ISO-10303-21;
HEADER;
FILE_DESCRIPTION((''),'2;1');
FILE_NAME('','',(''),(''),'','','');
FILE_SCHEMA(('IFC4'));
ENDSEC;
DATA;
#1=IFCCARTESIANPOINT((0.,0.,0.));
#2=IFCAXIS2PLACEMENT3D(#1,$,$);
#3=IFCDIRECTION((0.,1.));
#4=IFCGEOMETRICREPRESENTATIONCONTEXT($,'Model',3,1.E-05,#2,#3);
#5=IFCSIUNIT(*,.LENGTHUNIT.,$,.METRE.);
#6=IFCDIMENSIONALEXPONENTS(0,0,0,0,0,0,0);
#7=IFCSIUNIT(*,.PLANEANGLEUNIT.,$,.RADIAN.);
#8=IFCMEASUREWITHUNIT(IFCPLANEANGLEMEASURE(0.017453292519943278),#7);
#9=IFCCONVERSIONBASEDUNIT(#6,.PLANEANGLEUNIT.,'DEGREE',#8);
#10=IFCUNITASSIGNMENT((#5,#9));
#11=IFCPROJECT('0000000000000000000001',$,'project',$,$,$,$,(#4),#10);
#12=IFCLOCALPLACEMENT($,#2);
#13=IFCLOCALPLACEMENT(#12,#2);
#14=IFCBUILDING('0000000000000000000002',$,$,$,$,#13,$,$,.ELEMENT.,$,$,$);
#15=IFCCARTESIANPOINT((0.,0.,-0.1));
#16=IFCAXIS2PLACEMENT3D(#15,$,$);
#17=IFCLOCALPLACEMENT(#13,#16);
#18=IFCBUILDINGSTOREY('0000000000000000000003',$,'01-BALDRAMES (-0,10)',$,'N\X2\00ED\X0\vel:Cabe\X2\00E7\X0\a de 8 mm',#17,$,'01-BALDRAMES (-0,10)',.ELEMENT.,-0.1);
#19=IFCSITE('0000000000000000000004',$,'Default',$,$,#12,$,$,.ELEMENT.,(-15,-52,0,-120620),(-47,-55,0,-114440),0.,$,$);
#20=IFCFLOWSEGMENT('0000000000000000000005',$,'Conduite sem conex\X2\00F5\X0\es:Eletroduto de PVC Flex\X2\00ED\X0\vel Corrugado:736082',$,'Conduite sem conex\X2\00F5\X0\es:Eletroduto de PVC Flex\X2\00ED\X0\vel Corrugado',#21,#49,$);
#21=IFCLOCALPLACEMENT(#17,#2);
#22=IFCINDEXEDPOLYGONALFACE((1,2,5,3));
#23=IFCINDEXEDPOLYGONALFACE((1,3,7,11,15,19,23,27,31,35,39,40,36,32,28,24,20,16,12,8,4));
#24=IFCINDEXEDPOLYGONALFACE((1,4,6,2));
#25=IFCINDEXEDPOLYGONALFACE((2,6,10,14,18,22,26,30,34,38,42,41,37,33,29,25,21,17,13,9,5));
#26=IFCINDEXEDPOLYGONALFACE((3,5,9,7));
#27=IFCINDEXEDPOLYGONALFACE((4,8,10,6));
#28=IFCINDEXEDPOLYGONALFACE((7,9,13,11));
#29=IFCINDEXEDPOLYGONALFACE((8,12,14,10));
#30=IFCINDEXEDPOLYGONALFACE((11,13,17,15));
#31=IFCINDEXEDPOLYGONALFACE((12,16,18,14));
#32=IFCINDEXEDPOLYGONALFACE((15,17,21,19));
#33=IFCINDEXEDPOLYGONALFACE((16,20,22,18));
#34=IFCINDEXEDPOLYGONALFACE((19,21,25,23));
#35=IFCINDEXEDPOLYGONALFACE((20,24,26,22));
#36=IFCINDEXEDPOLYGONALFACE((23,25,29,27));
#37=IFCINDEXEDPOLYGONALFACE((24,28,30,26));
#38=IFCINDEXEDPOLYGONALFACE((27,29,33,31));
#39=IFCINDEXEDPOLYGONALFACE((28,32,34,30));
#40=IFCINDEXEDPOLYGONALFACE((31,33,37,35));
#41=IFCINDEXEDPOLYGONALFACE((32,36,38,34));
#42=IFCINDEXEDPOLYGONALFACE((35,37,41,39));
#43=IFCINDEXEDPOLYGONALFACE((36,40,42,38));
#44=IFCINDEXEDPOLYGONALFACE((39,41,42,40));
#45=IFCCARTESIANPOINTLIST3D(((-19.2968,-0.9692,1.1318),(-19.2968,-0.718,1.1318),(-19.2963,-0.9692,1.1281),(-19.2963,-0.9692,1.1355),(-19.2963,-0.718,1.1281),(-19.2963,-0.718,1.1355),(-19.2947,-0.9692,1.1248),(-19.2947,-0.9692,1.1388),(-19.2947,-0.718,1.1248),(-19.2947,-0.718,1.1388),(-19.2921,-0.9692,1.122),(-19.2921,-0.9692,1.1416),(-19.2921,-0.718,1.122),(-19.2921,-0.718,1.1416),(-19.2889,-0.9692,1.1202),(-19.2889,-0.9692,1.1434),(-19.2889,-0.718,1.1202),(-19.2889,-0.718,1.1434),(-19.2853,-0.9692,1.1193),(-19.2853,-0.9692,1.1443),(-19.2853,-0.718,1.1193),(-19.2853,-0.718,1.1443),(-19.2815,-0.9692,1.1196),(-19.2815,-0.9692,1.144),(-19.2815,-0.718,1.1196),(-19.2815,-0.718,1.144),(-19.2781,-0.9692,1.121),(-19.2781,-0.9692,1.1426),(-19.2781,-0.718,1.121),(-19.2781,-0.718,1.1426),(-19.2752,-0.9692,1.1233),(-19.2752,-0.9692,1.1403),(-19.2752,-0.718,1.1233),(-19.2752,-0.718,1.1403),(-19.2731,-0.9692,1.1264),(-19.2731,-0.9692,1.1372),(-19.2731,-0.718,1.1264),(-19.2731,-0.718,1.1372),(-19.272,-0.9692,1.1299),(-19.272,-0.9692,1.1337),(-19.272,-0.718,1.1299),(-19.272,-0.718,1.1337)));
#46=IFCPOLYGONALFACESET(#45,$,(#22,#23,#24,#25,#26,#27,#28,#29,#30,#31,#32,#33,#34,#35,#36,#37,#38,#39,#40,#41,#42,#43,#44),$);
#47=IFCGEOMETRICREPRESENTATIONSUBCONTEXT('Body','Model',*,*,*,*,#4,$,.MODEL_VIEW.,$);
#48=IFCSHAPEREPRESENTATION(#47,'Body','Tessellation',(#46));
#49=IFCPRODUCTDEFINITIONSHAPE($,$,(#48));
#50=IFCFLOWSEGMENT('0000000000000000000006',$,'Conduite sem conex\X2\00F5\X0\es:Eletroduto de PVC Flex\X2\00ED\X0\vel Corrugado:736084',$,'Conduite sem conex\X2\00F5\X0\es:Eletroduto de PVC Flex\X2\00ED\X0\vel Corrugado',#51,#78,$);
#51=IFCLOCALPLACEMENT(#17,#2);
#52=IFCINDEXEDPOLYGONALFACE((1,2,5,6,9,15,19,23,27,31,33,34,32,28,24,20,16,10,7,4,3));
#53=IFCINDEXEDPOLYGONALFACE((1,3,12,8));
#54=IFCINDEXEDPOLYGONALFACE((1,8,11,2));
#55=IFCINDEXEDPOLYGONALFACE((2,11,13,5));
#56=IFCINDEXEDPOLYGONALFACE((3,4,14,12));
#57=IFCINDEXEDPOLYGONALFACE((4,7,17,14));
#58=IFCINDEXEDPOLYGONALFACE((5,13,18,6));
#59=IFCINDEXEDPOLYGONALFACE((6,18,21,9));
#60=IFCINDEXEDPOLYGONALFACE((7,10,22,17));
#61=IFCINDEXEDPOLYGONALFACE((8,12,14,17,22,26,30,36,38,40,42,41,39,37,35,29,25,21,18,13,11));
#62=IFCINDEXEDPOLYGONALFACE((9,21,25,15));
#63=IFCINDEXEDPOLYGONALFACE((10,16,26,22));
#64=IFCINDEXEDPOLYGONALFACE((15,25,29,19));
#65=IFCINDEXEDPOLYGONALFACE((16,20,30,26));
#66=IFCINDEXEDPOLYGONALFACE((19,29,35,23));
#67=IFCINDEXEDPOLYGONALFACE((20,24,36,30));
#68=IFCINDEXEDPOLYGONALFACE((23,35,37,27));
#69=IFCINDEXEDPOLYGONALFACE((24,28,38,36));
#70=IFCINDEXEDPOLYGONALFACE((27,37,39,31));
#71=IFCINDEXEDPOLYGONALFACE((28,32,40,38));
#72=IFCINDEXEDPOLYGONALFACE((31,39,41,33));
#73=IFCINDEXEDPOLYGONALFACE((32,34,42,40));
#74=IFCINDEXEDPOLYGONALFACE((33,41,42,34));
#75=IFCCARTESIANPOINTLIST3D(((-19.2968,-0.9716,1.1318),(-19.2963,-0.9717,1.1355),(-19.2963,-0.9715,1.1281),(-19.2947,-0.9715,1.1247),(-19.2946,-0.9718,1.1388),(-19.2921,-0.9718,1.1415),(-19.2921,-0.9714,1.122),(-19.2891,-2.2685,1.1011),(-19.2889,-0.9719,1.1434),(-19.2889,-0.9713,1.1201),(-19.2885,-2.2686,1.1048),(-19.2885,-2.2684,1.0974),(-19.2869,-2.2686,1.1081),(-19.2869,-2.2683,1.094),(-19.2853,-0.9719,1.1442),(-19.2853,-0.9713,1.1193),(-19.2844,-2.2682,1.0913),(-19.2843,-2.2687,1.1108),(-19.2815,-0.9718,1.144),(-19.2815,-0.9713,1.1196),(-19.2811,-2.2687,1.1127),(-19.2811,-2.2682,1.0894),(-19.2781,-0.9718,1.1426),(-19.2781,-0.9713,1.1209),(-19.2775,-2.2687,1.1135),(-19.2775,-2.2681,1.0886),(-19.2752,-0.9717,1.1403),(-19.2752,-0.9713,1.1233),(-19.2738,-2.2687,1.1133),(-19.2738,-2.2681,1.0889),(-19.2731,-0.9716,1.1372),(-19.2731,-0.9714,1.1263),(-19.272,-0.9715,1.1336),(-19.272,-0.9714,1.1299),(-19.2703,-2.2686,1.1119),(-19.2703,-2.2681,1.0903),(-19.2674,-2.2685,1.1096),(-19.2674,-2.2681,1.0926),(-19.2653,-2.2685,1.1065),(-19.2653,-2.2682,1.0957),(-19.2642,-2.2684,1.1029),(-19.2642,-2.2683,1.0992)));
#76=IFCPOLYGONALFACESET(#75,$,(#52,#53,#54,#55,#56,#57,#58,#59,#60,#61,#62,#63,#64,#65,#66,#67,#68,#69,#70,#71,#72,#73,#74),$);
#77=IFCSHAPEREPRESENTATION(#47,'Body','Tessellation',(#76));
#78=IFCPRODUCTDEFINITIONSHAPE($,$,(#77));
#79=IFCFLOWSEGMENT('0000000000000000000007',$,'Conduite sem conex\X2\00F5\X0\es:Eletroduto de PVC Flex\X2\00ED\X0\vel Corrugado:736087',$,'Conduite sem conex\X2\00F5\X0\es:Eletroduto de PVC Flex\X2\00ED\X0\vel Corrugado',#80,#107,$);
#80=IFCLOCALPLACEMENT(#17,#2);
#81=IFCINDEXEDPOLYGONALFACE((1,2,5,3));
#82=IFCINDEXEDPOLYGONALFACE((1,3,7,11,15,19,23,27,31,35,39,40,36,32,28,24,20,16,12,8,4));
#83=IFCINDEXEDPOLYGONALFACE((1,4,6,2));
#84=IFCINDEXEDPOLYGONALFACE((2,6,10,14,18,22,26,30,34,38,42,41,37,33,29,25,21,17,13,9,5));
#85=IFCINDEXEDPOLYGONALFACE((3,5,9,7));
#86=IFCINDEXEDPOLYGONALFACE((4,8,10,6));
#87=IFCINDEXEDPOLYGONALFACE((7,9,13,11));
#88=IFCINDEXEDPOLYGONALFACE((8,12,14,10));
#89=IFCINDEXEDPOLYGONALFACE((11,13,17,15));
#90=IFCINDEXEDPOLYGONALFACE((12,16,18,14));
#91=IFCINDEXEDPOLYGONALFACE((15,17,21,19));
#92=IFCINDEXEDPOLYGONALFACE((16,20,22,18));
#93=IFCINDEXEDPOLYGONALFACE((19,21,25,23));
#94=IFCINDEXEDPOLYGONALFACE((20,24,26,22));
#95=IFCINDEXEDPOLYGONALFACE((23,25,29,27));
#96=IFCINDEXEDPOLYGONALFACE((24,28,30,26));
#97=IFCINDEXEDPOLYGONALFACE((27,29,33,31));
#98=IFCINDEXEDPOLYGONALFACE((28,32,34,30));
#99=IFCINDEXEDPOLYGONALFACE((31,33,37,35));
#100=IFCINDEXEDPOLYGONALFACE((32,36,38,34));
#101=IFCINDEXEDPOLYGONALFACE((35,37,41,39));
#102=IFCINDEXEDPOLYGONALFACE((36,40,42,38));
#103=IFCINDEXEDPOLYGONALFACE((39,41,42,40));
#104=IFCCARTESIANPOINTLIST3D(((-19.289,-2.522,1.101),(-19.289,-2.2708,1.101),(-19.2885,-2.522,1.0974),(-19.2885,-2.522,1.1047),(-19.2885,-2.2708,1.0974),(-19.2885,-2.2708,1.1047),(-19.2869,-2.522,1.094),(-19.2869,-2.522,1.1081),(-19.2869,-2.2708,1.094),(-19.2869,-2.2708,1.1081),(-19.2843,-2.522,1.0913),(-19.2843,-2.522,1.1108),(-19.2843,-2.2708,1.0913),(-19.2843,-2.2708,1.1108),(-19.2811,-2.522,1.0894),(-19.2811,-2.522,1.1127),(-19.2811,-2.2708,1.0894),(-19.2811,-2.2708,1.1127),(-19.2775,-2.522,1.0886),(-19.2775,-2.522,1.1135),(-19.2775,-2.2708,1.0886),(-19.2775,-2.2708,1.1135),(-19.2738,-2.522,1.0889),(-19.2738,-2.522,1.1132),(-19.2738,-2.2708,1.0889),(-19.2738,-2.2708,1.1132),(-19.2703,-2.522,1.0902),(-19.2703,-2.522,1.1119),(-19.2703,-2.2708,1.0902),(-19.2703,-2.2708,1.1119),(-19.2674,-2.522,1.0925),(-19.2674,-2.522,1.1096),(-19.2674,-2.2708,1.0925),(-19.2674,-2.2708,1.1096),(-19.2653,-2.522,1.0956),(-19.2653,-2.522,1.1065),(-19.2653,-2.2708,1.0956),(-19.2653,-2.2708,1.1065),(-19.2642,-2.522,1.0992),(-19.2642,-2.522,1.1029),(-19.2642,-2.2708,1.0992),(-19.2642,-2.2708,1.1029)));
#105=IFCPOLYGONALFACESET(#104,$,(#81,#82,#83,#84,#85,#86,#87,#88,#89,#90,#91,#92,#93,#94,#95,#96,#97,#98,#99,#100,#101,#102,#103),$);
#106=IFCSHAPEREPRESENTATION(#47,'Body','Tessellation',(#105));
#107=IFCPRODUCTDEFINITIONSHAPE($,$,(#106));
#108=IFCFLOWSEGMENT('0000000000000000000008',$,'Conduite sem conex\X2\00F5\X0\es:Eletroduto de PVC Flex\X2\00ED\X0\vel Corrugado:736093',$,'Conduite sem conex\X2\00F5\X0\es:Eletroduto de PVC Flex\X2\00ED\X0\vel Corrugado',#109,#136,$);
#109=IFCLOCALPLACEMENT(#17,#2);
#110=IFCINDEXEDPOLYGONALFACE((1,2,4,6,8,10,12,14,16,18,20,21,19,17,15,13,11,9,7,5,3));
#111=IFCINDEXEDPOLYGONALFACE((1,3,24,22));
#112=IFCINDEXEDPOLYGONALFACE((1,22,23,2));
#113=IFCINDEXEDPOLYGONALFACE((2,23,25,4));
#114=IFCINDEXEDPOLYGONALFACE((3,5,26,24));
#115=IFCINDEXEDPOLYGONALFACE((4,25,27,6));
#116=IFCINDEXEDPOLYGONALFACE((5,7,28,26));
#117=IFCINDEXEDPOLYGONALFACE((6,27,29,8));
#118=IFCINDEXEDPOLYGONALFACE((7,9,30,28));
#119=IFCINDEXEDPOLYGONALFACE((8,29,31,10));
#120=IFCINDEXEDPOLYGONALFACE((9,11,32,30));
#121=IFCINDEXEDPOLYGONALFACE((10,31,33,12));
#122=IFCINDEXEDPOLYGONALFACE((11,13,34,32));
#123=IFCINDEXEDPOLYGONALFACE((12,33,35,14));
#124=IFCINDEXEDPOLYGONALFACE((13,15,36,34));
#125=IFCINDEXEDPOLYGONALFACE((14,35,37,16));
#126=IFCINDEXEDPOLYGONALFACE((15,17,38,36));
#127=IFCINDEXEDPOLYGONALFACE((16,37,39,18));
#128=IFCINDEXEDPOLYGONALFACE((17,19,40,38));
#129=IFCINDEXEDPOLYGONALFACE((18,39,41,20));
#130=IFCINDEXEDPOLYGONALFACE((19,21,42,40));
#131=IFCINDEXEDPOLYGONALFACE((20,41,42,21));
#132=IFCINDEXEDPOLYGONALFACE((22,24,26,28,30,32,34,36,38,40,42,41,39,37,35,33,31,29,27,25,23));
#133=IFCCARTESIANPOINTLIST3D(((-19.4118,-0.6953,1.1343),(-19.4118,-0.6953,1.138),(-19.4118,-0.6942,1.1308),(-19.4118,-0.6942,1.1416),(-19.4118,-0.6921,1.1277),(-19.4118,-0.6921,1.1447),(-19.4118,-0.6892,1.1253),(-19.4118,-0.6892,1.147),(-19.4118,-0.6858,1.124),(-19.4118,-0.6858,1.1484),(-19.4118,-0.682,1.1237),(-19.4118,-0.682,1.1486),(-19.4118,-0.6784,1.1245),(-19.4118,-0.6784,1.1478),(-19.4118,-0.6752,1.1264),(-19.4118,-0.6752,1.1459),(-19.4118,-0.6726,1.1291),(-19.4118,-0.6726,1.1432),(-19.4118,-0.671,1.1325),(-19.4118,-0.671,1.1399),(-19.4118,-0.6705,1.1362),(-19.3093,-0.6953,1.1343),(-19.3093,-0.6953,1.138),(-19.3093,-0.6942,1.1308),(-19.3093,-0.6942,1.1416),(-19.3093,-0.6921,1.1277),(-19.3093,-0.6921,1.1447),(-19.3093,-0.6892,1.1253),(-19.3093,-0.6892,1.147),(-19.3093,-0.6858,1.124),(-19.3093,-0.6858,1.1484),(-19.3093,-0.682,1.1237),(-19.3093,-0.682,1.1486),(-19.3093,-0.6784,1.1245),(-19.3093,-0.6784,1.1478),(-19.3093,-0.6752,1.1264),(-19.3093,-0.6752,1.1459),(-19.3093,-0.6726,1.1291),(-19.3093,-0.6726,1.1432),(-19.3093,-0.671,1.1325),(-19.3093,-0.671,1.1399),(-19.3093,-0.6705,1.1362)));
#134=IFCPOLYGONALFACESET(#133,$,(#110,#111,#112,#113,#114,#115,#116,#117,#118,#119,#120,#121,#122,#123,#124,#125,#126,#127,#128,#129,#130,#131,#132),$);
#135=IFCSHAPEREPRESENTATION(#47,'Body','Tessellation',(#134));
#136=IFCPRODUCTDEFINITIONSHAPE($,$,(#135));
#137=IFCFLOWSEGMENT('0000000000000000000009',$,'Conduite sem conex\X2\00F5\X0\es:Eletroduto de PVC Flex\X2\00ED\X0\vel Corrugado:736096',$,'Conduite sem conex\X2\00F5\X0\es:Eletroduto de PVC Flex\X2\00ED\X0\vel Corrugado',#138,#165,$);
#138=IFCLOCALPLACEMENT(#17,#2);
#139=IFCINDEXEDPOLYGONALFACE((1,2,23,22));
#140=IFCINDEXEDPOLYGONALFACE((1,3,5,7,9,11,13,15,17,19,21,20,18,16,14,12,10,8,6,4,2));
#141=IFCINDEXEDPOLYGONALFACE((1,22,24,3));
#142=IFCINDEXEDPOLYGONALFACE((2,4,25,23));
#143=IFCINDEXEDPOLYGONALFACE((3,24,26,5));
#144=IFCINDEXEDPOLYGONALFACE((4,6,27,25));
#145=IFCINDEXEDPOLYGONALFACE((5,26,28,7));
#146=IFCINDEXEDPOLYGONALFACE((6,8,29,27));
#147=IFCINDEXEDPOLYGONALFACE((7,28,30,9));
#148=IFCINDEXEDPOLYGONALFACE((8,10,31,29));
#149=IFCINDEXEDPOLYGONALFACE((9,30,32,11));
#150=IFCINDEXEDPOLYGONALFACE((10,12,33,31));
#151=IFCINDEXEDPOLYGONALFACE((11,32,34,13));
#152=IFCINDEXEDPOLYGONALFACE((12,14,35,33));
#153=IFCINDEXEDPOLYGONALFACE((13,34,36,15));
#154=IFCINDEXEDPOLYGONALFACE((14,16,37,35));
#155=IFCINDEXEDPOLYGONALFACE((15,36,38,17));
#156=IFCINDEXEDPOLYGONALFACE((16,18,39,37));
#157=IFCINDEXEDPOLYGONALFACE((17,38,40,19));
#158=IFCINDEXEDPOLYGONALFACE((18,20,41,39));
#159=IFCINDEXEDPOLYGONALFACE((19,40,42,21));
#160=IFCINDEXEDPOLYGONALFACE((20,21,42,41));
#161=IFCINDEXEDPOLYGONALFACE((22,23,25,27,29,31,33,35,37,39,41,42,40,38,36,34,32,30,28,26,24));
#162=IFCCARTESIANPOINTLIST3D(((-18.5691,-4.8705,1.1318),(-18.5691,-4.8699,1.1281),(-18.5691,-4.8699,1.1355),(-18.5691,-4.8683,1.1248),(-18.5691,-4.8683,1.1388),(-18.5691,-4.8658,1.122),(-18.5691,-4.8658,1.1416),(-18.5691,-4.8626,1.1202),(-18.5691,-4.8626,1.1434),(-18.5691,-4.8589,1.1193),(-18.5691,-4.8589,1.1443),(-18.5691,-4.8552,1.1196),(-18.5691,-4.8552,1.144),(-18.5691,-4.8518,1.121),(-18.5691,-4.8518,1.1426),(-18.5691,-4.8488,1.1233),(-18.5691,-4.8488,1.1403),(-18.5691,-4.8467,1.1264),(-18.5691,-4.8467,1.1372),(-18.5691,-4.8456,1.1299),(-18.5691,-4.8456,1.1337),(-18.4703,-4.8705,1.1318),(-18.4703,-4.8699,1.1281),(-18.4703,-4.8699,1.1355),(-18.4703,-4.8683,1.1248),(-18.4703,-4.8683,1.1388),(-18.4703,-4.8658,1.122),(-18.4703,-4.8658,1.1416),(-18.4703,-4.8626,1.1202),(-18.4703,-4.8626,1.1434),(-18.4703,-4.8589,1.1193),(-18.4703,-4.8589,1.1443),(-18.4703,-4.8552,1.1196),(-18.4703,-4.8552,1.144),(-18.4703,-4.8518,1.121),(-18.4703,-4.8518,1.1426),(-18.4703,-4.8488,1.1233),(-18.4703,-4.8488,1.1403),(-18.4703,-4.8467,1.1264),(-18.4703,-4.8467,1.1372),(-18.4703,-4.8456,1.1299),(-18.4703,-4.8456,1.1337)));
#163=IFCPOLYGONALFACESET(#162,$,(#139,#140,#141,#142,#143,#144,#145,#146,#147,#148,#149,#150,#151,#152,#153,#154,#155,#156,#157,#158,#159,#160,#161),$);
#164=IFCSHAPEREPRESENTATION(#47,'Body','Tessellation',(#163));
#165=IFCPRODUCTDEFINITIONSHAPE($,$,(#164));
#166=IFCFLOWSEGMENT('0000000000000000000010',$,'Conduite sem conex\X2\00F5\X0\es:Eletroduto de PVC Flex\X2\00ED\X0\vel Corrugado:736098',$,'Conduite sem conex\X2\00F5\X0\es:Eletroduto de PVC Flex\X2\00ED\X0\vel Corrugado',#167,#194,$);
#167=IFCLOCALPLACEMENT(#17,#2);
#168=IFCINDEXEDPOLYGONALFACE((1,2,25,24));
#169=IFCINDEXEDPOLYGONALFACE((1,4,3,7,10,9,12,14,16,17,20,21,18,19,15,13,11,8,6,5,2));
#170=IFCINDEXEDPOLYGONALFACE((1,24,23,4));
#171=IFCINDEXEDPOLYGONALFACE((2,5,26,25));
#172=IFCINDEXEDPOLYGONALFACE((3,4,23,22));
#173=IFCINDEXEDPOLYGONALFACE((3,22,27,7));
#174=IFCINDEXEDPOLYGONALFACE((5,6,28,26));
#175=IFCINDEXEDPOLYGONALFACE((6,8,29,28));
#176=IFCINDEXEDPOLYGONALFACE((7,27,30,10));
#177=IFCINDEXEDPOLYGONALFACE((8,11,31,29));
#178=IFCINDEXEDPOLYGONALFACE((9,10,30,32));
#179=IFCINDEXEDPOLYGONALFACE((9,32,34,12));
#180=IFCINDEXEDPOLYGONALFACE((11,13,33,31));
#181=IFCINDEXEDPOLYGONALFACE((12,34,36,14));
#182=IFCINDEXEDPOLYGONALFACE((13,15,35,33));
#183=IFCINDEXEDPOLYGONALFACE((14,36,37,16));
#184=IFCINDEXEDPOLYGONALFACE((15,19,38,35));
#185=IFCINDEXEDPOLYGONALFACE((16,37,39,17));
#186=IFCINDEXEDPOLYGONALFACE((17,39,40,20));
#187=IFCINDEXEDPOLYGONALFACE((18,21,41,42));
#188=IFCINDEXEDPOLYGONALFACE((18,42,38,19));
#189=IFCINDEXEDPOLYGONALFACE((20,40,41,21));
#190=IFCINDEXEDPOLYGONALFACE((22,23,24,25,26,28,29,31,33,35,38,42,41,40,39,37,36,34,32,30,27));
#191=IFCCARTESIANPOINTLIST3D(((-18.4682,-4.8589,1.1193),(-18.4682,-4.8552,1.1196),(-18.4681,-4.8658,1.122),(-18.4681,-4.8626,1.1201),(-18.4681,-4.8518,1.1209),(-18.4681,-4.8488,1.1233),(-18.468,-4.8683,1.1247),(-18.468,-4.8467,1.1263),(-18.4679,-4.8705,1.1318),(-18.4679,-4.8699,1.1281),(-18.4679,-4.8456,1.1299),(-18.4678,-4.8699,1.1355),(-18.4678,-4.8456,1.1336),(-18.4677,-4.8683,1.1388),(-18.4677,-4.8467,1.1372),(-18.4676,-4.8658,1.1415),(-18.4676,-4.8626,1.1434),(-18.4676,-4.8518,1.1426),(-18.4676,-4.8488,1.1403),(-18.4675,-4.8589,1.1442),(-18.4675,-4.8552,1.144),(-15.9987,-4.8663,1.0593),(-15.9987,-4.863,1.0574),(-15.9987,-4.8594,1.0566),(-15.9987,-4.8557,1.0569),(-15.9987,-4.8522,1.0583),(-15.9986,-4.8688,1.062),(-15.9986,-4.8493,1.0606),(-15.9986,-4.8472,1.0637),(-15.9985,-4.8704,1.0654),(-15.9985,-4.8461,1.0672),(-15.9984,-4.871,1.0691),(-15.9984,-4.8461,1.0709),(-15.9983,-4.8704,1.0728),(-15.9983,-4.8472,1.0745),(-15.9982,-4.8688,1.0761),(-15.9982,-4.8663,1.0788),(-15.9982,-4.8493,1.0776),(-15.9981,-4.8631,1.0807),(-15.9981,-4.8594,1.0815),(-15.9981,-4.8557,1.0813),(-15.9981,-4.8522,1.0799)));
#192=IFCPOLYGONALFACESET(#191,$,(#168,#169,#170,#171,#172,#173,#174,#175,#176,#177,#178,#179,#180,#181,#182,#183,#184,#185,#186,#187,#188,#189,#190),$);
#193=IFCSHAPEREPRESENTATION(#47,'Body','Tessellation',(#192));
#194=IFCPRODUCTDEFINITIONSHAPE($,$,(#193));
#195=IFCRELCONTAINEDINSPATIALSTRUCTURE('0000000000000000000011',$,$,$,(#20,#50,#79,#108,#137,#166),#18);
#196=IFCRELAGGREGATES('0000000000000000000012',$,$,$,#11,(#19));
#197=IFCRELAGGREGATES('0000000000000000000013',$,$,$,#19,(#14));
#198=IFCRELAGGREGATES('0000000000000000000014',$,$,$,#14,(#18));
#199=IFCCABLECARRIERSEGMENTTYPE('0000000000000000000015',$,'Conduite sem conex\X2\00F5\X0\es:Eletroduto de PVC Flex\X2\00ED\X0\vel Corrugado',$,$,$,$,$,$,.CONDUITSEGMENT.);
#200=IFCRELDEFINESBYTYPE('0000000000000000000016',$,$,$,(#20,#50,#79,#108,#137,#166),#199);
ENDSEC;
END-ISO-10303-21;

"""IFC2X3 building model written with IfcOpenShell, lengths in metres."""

from ifc_helpers import new_model, entity, si_unit, converted_unit, direction, frame, frame_2d, origin, origin_2d_with_axis, place, context, subcontext, project, spatial, circle, extrude, type_object, element, save


model = new_model("IFC2X3")

# Units and contexts
model_context = context("Model", 3, precision=1e-05, world=origin(), true_north=direction((0.0, 1.0)))
body_context = subcontext(model_context, "Body", "Model", "MODEL_VIEW")
ifc_project = project(units=[si_unit("LENGTHUNIT", "METRE"), converted_unit("PLANEANGLEUNIT", "DEGREE", entity("IfcPlaneAngleMeasure", 0.017453292519943278), si_unit("PLANEANGLEUNIT", "RADIAN"), dimensions=[0, 0, 0, 0, 0, 0, 0])], contexts=[model_context])

# Site, building, storey
site_placement = place(None, origin())
site = spatial("IfcSite", under=ifc_project, at=site_placement, Name="Default", CompositionType="ELEMENT", RefLatitude=(-15, -52, 0, -120620), RefLongitude=(-47, -55, 0, -114440), RefElevation=0.0)
building_placement = place(site_placement, origin())
building = spatial("IfcBuilding", under=site, at=building_placement, CompositionType="ELEMENT")
storey_placement = place(building_placement, frame((0.0, 0.0, -0.1)))
storey = spatial("IfcBuildingStorey", under=building, at=storey_placement, Name="01-BALDRAMES (-0,10)", ObjectType="Nível:Cabeça de 8 mm", LongName="01-BALDRAMES (-0,10)", CompositionType="ELEMENT", Elevation=-0.1)

# Flow segments
cable_carrier_segment_type = type_object("IfcCableCarrierSegmentType", Name="Conduite sem conexões:Eletroduto de PVC Flexível Corrugado", PredefinedType="CONDUITSEGMENT")
flow_segment_1_placement = place(storey_placement, origin())
element("IfcFlowSegment", 1, at=flow_segment_1_placement, inside=storey, type_object=cable_carrier_segment_type, Name="Conduite sem conexões:Eletroduto de PVC Flexível Corrugado:736082", ObjectType="Conduite sem conexões:Eletroduto de PVC Flexível Corrugado", context=body_context, shape_type="SweptSolid", body=[
    extrude(circle(Radius=0.0125, at=frame_2d((0.0, 0.0), x_axis=(1.0, 0.0))), frame((-19.2843, -0.9692, 1.1318), z_axis=(0.0, 1.0, 0.0), x_axis=(-1.0, 0.0, 0.0)), (0.0, 0.0, 1.0), 0.2512),
])
flow_segment_2_placement = place(storey_placement, origin())
element("IfcFlowSegment", 2, at=flow_segment_2_placement, inside=storey, type_object=cable_carrier_segment_type, Name="Conduite sem conexões:Eletroduto de PVC Flexível Corrugado:736084", ObjectType="Conduite sem conexões:Eletroduto de PVC Flexível Corrugado", context=body_context, shape_type="SweptSolid", body=[
    extrude(circle(Radius=0.0125, at=frame_2d((0.0, 0.0), x_axis=(1.0, 0.0))), frame((-19.2766, -2.2684, 1.1011), z_axis=(-0.005987, 0.999702, 0.023661), x_axis=(-0.999982, -0.005988, 0.0)), (0.0, 0.0, 1.0), 1.2972),
])
flow_segment_3_placement = place(storey_placement, origin())
element("IfcFlowSegment", 3, at=flow_segment_3_placement, inside=storey, type_object=cable_carrier_segment_type, Name="Conduite sem conexões:Eletroduto de PVC Flexível Corrugado:736087", ObjectType="Conduite sem conexões:Eletroduto de PVC Flexível Corrugado", context=body_context, shape_type="SweptSolid", body=[
    extrude(circle(Radius=0.0125, at=frame_2d((0.0, 0.0), x_axis=(1.0, 0.0))), frame((-19.2765, -2.522, 1.101), z_axis=(0.000002, 1.0, 0.0), x_axis=(-1.0, 0.000002, 0.0)), (0.0, 0.0, 1.0), 0.2512),
])
flow_segment_4_placement = place(storey_placement, origin())
element("IfcFlowSegment", 4, at=flow_segment_4_placement, inside=storey, type_object=cable_carrier_segment_type, Name="Conduite sem conexões:Eletroduto de PVC Flexível Corrugado:736093", ObjectType="Conduite sem conexões:Eletroduto de PVC Flexível Corrugado", context=body_context, shape_type="SweptSolid", body=[
    extrude(circle(Radius=0.0125, at=frame_2d((0.0, 0.0), x_axis=(1.0, 0.0))), frame((-19.4118, -0.683, 1.1362), z_axis=(1.0, 0.0, 0.0), x_axis=(0.0, 1.0, 0.0)), (0.0, 0.0, 1.0), 0.1025),
])
flow_segment_5_placement = place(storey_placement, origin())
element("IfcFlowSegment", 5, at=flow_segment_5_placement, inside=storey, type_object=cable_carrier_segment_type, Name="Conduite sem conexões:Eletroduto de PVC Flexível Corrugado:736096", ObjectType="Conduite sem conexões:Eletroduto de PVC Flexível Corrugado", context=body_context, shape_type="SweptSolid", body=[
    extrude(circle(Radius=0.0125, at=origin_2d_with_axis()), frame((-18.5691, -4.858, 1.1318), z_axis=(1.0, 0.0, 0.0), x_axis=(0.0, -1.0, 0.0)), (0.0, 0.0, 1.0), 0.0988),
])
flow_segment_6_placement = place(storey_placement, origin())
element("IfcFlowSegment", 6, at=flow_segment_6_placement, inside=storey, type_object=cable_carrier_segment_type, Name="Conduite sem conexões:Eletroduto de PVC Flexível Corrugado:736098", ObjectType="Conduite sem conexões:Eletroduto de PVC Flexível Corrugado", context=body_context, shape_type="SweptSolid", body=[
    extrude(circle(Radius=0.0125, at=origin_2d_with_axis()), frame((-15.9984, -4.8585, 1.0691), z_axis=(-0.999678, 0.000195, 0.025378), x_axis=(-0.000195, -1.0, 0.0)), (0.0, 0.0, 1.0), 2.4702),
])

save(model, "model.ifc")
